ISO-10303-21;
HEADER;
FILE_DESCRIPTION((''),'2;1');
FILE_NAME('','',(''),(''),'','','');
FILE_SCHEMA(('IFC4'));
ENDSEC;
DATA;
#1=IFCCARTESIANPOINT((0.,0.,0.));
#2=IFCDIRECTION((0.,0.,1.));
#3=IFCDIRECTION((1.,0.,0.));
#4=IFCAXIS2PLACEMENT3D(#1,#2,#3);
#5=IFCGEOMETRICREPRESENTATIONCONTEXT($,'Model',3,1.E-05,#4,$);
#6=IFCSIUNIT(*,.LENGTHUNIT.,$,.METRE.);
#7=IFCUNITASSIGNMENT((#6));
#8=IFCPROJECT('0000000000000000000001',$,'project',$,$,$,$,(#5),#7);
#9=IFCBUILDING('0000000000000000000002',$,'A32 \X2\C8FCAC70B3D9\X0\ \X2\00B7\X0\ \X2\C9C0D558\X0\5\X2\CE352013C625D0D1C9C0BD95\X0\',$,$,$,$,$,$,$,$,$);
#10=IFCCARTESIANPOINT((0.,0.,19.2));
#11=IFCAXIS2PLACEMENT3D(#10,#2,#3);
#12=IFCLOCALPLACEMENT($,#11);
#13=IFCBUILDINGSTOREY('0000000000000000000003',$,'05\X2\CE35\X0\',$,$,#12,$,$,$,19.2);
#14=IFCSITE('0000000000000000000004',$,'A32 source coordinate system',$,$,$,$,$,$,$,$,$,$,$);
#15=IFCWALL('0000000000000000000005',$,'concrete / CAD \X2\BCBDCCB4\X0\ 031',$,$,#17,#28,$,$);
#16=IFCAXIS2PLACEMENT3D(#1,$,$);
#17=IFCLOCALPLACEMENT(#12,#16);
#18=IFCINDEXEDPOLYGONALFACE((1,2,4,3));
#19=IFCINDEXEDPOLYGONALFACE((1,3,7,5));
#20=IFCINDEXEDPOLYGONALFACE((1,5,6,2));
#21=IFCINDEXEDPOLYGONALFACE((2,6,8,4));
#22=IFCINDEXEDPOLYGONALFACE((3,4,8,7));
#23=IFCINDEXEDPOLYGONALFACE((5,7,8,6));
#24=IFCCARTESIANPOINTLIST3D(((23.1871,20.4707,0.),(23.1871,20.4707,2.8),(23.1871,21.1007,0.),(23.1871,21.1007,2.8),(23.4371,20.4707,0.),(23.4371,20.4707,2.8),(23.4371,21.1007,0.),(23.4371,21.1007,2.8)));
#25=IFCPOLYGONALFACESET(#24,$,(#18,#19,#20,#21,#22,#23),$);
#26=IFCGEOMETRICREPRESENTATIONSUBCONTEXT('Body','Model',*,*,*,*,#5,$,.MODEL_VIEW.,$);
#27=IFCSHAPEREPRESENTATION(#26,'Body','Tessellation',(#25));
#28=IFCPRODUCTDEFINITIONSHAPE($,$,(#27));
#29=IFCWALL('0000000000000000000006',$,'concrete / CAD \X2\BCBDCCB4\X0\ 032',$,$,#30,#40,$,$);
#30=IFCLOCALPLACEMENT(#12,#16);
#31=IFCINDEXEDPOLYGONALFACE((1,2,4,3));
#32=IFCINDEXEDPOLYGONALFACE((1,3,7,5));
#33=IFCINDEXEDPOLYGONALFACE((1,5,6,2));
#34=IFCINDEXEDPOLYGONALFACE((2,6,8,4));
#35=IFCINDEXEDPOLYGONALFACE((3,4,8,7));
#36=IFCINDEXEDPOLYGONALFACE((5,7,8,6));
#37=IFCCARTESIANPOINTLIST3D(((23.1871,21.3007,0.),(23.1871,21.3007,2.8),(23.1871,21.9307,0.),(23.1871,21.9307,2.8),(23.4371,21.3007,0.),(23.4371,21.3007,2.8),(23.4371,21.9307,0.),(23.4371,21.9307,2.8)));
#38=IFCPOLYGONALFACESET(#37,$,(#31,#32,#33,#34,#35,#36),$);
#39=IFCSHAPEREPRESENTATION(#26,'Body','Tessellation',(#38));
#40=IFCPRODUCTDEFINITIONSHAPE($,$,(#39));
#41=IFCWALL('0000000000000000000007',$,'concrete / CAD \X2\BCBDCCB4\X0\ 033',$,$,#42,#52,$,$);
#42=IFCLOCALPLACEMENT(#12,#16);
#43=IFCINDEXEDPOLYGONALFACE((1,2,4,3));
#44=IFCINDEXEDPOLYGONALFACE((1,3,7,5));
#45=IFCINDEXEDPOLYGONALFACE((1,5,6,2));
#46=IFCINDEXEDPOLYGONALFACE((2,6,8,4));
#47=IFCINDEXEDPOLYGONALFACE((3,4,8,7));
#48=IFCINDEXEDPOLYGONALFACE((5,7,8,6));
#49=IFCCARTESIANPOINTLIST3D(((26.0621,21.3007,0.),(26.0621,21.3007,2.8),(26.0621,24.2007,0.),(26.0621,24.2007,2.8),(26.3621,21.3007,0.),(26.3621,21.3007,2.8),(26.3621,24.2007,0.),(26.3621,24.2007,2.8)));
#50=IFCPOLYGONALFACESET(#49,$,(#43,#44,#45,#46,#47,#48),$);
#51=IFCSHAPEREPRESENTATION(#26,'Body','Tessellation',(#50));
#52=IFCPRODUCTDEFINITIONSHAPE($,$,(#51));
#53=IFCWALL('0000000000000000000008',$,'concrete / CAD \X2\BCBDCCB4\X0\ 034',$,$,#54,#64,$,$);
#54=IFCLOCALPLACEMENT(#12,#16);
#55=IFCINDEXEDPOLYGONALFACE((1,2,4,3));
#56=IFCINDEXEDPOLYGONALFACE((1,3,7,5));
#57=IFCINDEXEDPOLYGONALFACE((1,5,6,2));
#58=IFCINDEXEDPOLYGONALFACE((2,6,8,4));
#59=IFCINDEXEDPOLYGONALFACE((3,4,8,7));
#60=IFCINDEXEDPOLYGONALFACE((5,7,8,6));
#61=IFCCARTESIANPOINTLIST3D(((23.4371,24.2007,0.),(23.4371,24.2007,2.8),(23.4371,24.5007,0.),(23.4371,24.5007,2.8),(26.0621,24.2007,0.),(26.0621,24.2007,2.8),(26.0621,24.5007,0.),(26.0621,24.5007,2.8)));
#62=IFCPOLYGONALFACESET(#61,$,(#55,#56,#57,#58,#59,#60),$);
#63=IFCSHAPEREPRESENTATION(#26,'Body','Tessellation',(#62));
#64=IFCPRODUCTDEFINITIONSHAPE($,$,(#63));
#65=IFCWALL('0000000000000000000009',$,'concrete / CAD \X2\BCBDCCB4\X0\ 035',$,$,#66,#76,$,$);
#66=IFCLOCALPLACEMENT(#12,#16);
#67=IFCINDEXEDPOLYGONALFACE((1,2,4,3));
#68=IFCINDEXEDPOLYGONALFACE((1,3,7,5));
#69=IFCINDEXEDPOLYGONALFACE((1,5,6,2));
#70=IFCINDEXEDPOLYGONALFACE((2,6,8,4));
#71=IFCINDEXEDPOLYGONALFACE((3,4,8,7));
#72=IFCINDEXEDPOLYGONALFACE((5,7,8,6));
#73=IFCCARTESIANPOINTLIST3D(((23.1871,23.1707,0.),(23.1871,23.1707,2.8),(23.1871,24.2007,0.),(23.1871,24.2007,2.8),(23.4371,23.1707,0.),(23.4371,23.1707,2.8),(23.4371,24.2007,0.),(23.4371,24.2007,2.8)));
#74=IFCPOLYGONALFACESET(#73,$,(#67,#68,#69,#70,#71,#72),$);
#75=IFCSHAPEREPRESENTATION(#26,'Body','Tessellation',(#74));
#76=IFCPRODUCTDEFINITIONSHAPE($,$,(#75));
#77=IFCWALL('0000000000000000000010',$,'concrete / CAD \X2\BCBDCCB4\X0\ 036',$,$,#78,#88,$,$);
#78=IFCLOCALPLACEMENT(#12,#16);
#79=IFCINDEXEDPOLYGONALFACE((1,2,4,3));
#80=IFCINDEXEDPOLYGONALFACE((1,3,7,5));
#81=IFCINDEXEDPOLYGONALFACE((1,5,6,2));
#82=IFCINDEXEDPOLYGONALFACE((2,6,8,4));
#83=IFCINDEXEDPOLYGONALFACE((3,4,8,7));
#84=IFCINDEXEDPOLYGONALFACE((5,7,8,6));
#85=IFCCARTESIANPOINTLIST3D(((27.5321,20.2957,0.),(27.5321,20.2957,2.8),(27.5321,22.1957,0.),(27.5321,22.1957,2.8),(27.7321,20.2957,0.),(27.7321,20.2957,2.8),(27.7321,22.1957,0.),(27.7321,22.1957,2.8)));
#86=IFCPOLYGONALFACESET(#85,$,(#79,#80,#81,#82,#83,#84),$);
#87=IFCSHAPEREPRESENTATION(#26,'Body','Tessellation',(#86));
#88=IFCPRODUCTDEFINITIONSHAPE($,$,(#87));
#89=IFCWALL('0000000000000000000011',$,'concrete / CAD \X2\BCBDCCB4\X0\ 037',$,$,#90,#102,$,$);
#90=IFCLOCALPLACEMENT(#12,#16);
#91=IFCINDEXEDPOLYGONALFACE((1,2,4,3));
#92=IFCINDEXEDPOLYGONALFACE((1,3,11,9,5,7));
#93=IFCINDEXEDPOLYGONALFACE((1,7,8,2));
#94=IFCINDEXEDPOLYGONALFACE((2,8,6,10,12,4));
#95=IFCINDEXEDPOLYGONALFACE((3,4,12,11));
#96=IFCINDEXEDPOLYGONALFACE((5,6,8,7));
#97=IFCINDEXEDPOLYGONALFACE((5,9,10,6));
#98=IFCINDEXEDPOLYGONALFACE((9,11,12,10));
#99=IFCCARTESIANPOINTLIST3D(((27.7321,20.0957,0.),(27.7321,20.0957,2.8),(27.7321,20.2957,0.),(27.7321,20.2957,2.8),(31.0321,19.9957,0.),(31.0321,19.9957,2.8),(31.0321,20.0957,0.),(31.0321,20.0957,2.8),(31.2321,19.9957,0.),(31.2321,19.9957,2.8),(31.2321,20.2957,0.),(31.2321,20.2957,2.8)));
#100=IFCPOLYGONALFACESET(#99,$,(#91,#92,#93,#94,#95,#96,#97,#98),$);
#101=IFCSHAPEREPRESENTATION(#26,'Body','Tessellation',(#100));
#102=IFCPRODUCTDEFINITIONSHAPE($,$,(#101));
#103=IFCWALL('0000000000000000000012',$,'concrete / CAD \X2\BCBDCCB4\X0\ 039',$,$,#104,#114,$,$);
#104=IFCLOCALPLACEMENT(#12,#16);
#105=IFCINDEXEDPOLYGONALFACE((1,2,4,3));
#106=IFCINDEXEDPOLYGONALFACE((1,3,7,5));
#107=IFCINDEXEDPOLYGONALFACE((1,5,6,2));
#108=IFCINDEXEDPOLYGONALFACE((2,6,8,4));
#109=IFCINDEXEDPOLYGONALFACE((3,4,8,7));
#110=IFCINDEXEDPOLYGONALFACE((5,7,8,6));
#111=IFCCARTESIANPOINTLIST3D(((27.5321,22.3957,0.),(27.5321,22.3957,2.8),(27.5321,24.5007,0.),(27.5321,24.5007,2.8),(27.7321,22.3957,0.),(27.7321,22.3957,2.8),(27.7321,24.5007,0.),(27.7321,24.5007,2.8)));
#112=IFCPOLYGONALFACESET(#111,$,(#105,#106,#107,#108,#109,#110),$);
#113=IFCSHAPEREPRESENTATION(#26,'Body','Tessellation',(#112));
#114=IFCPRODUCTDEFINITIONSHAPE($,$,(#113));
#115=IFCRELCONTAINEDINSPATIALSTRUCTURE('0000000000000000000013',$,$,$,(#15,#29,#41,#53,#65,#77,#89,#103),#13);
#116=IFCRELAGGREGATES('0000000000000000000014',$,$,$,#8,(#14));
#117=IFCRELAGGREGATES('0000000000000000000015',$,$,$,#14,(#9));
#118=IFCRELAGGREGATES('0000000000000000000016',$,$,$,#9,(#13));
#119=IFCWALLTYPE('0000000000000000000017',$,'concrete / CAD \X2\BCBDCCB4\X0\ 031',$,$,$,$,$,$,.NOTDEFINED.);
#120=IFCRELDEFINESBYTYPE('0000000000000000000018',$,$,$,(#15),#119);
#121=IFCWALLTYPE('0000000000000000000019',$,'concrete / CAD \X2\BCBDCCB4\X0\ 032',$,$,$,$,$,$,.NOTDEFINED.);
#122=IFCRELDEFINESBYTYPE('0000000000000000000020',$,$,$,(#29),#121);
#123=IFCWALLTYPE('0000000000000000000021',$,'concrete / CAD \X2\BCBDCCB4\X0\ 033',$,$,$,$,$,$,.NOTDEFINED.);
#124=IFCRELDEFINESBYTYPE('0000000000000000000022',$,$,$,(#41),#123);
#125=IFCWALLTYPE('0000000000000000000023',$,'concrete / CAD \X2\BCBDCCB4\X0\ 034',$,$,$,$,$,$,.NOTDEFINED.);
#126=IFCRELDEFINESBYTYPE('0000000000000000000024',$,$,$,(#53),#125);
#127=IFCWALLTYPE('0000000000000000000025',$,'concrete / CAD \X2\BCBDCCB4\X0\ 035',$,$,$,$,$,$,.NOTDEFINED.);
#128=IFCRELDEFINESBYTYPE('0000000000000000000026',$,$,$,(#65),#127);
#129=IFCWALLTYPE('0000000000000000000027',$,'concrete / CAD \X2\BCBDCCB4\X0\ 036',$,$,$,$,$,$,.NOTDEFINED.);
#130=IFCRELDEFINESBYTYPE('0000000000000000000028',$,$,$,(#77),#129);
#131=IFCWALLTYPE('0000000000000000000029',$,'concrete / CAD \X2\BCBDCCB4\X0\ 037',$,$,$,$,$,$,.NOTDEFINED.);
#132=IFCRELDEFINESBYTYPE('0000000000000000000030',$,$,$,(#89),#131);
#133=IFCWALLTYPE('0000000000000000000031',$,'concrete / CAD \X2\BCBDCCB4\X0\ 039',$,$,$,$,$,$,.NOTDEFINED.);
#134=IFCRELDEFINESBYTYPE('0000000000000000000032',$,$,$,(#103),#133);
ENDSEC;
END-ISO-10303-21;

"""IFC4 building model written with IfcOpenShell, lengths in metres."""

from ifc_helpers import new_model, si_unit, frame, origin, origin_with_axes, place, context, subcontext, project, spatial, polyline, outline, extrude, source, transform, mapped, type_object, type_shapes, element, save


model = new_model("IFC4")

# Units and contexts
model_context = context("Model", 3, precision=1e-05, world=origin_with_axes())
body_context = subcontext(model_context, "Body", "Model", "MODEL_VIEW")
ifc_project = project(units=[si_unit("LENGTHUNIT", "METRE")], contexts=[model_context])

# Site, building, storey
site = spatial("IfcSite", under=ifc_project, Name="A32 source coordinate system")
building = spatial("IfcBuilding", under=site, Name="A32 주거동 · 지하5층–옥탑지붕")
storey_placement = place(None, frame((0.0, 0.0, 19.2), z_axis=(0.0, 0.0, 1.0), x_axis=(1.0, 0.0, 0.0)))
storey = spatial("IfcBuildingStorey", under=building, at=storey_placement, Name="05층", Elevation=19.2)

# Walls
wall_type_1 = type_object("IfcWallType", Name="concrete / CAD 벽체 031", PredefinedType="NOTDEFINED")
shared_shape_1 = source(origin(), body_context, "Body", "SweptSolid", [
    extrude(outline(polyline([(23.1871, 20.4707), (23.1871, 21.1007), (23.4371, 21.1007), (23.4371, 20.4707), (23.1871, 20.4707)])), origin(), (0.0, 0.0, 1.0), 2.8),
])
type_shapes(wall_type_1, [shared_shape_1])
wall_1_placement = place(storey_placement, origin_with_axes())
element("IfcWall", 1, at=wall_1_placement, inside=storey, type_object=wall_type_1, Name="concrete / CAD 벽체 031", context=body_context, shape_type="MappedRepresentation", body=[
    mapped(shared_shape_1, transform((0.0, 0.0, 0.0), scale=1.0)),
])
wall_type_2 = type_object("IfcWallType", Name="concrete / CAD 벽체 032", PredefinedType="NOTDEFINED")
shared_shape_2 = source(origin(), body_context, "Body", "SweptSolid", [
    extrude(outline(polyline([(23.4371, 21.9307), (23.4371, 21.3007), (23.1871, 21.3007), (23.1871, 21.9307), (23.4371, 21.9307)])), origin(), (0.0, 0.0, 1.0), 2.8),
])
type_shapes(wall_type_2, [shared_shape_2])
wall_2_placement = place(storey_placement, origin_with_axes())
element("IfcWall", 2, at=wall_2_placement, inside=storey, type_object=wall_type_2, Name="concrete / CAD 벽체 032", context=body_context, shape_type="MappedRepresentation", body=[
    mapped(shared_shape_2, transform((0.0, 0.0, 0.0), scale=1.0)),
])
wall_type_3 = type_object("IfcWallType", Name="concrete / CAD 벽체 033", PredefinedType="NOTDEFINED")
shared_shape_3 = source(origin(), body_context, "Body", "SweptSolid", [
    extrude(outline(polyline([(26.3621, 24.2007), (26.3621, 21.3007), (26.0621, 21.3007), (26.0621, 24.2007), (26.3621, 24.2007)])), origin(), (0.0, 0.0, 1.0), 2.8),
])
type_shapes(wall_type_3, [shared_shape_3])
wall_3_placement = place(storey_placement, origin_with_axes())
element("IfcWall", 3, at=wall_3_placement, inside=storey, type_object=wall_type_3, Name="concrete / CAD 벽체 033", context=body_context, shape_type="MappedRepresentation", body=[
    mapped(shared_shape_3, transform((0.0, 0.0, 0.0), scale=1.0)),
])
wall_type_4 = type_object("IfcWallType", Name="concrete / CAD 벽체 034", PredefinedType="NOTDEFINED")
shared_shape_4 = source(origin(), body_context, "Body", "SweptSolid", [
    extrude(outline(polyline([(23.4371, 24.5007), (26.0621, 24.5007), (26.0621, 24.2007), (23.4371, 24.2007), (23.4371, 24.5007)])), origin(), (0.0, 0.0, 1.0), 2.8),
])
type_shapes(wall_type_4, [shared_shape_4])
wall_4_placement = place(storey_placement, origin_with_axes())
element("IfcWall", 4, at=wall_4_placement, inside=storey, type_object=wall_type_4, Name="concrete / CAD 벽체 034", context=body_context, shape_type="MappedRepresentation", body=[
    mapped(shared_shape_4, transform((0.0, 0.0, 0.0), scale=1.0)),
])
wall_type_5 = type_object("IfcWallType", Name="concrete / CAD 벽체 035", PredefinedType="NOTDEFINED")
shared_shape_5 = source(origin(), body_context, "Body", "SweptSolid", [
    extrude(outline(polyline([(23.1871, 23.1707), (23.1871, 24.2007), (23.4371, 24.2007), (23.4371, 23.1707), (23.1871, 23.1707)])), origin(), (0.0, 0.0, 1.0), 2.8),
])
type_shapes(wall_type_5, [shared_shape_5])
wall_5_placement = place(storey_placement, origin_with_axes())
element("IfcWall", 5, at=wall_5_placement, inside=storey, type_object=wall_type_5, Name="concrete / CAD 벽체 035", context=body_context, shape_type="MappedRepresentation", body=[
    mapped(shared_shape_5, transform((0.0, 0.0, 0.0), scale=1.0)),
])
wall_type_6 = type_object("IfcWallType", Name="concrete / CAD 벽체 036", PredefinedType="NOTDEFINED")
shared_shape_6 = source(origin(), body_context, "Body", "SweptSolid", [
    extrude(outline(polyline([(27.7321, 22.1957), (27.7321, 20.2957), (27.5321, 20.2957), (27.5321, 22.1957), (27.7321, 22.1957)])), origin(), (0.0, 0.0, 1.0), 2.8),
])
type_shapes(wall_type_6, [shared_shape_6])
wall_6_placement = place(storey_placement, origin_with_axes())
element("IfcWall", 6, at=wall_6_placement, inside=storey, type_object=wall_type_6, Name="concrete / CAD 벽체 036", context=body_context, shape_type="MappedRepresentation", body=[
    mapped(shared_shape_6, transform((0.0, 0.0, 0.0), scale=1.0)),
])
wall_type_7 = type_object("IfcWallType", Name="concrete / CAD 벽체 037", PredefinedType="NOTDEFINED")
shared_shape_7 = source(origin(), body_context, "Body", "SweptSolid", [
    extrude(outline(polyline([(31.2321, 19.9957), (31.0321, 19.9957), (31.0321, 20.0957), (27.7321, 20.0957), (27.7321, 20.2957), (31.2321, 20.2957), (31.2321, 19.9957)])), origin(), (0.0, 0.0, 1.0), 2.8),
])
type_shapes(wall_type_7, [shared_shape_7])
wall_7_placement = place(storey_placement, origin_with_axes())
element("IfcWall", 7, at=wall_7_placement, inside=storey, type_object=wall_type_7, Name="concrete / CAD 벽체 037", context=body_context, shape_type="MappedRepresentation", body=[
    mapped(shared_shape_7, transform((0.0, 0.0, 0.0), scale=1.0)),
])
wall_type_8 = type_object("IfcWallType", Name="concrete / CAD 벽체 039", PredefinedType="NOTDEFINED")
shared_shape_8 = source(origin(), body_context, "Body", "SweptSolid", [
    extrude(outline(polyline([(27.7321, 24.5007), (27.7321, 22.3957), (27.5321, 22.3957), (27.5321, 24.5007), (27.7321, 24.5007)])), origin(), (0.0, 0.0, 1.0), 2.8),
])
type_shapes(wall_type_8, [shared_shape_8])
wall_8_placement = place(storey_placement, origin_with_axes())
element("IfcWall", 8, at=wall_8_placement, inside=storey, type_object=wall_type_8, Name="concrete / CAD 벽체 039", context=body_context, shape_type="MappedRepresentation", body=[
    mapped(shared_shape_8, transform((0.0, 0.0, 0.0), scale=1.0)),
])

save(model, "model.ifc")
